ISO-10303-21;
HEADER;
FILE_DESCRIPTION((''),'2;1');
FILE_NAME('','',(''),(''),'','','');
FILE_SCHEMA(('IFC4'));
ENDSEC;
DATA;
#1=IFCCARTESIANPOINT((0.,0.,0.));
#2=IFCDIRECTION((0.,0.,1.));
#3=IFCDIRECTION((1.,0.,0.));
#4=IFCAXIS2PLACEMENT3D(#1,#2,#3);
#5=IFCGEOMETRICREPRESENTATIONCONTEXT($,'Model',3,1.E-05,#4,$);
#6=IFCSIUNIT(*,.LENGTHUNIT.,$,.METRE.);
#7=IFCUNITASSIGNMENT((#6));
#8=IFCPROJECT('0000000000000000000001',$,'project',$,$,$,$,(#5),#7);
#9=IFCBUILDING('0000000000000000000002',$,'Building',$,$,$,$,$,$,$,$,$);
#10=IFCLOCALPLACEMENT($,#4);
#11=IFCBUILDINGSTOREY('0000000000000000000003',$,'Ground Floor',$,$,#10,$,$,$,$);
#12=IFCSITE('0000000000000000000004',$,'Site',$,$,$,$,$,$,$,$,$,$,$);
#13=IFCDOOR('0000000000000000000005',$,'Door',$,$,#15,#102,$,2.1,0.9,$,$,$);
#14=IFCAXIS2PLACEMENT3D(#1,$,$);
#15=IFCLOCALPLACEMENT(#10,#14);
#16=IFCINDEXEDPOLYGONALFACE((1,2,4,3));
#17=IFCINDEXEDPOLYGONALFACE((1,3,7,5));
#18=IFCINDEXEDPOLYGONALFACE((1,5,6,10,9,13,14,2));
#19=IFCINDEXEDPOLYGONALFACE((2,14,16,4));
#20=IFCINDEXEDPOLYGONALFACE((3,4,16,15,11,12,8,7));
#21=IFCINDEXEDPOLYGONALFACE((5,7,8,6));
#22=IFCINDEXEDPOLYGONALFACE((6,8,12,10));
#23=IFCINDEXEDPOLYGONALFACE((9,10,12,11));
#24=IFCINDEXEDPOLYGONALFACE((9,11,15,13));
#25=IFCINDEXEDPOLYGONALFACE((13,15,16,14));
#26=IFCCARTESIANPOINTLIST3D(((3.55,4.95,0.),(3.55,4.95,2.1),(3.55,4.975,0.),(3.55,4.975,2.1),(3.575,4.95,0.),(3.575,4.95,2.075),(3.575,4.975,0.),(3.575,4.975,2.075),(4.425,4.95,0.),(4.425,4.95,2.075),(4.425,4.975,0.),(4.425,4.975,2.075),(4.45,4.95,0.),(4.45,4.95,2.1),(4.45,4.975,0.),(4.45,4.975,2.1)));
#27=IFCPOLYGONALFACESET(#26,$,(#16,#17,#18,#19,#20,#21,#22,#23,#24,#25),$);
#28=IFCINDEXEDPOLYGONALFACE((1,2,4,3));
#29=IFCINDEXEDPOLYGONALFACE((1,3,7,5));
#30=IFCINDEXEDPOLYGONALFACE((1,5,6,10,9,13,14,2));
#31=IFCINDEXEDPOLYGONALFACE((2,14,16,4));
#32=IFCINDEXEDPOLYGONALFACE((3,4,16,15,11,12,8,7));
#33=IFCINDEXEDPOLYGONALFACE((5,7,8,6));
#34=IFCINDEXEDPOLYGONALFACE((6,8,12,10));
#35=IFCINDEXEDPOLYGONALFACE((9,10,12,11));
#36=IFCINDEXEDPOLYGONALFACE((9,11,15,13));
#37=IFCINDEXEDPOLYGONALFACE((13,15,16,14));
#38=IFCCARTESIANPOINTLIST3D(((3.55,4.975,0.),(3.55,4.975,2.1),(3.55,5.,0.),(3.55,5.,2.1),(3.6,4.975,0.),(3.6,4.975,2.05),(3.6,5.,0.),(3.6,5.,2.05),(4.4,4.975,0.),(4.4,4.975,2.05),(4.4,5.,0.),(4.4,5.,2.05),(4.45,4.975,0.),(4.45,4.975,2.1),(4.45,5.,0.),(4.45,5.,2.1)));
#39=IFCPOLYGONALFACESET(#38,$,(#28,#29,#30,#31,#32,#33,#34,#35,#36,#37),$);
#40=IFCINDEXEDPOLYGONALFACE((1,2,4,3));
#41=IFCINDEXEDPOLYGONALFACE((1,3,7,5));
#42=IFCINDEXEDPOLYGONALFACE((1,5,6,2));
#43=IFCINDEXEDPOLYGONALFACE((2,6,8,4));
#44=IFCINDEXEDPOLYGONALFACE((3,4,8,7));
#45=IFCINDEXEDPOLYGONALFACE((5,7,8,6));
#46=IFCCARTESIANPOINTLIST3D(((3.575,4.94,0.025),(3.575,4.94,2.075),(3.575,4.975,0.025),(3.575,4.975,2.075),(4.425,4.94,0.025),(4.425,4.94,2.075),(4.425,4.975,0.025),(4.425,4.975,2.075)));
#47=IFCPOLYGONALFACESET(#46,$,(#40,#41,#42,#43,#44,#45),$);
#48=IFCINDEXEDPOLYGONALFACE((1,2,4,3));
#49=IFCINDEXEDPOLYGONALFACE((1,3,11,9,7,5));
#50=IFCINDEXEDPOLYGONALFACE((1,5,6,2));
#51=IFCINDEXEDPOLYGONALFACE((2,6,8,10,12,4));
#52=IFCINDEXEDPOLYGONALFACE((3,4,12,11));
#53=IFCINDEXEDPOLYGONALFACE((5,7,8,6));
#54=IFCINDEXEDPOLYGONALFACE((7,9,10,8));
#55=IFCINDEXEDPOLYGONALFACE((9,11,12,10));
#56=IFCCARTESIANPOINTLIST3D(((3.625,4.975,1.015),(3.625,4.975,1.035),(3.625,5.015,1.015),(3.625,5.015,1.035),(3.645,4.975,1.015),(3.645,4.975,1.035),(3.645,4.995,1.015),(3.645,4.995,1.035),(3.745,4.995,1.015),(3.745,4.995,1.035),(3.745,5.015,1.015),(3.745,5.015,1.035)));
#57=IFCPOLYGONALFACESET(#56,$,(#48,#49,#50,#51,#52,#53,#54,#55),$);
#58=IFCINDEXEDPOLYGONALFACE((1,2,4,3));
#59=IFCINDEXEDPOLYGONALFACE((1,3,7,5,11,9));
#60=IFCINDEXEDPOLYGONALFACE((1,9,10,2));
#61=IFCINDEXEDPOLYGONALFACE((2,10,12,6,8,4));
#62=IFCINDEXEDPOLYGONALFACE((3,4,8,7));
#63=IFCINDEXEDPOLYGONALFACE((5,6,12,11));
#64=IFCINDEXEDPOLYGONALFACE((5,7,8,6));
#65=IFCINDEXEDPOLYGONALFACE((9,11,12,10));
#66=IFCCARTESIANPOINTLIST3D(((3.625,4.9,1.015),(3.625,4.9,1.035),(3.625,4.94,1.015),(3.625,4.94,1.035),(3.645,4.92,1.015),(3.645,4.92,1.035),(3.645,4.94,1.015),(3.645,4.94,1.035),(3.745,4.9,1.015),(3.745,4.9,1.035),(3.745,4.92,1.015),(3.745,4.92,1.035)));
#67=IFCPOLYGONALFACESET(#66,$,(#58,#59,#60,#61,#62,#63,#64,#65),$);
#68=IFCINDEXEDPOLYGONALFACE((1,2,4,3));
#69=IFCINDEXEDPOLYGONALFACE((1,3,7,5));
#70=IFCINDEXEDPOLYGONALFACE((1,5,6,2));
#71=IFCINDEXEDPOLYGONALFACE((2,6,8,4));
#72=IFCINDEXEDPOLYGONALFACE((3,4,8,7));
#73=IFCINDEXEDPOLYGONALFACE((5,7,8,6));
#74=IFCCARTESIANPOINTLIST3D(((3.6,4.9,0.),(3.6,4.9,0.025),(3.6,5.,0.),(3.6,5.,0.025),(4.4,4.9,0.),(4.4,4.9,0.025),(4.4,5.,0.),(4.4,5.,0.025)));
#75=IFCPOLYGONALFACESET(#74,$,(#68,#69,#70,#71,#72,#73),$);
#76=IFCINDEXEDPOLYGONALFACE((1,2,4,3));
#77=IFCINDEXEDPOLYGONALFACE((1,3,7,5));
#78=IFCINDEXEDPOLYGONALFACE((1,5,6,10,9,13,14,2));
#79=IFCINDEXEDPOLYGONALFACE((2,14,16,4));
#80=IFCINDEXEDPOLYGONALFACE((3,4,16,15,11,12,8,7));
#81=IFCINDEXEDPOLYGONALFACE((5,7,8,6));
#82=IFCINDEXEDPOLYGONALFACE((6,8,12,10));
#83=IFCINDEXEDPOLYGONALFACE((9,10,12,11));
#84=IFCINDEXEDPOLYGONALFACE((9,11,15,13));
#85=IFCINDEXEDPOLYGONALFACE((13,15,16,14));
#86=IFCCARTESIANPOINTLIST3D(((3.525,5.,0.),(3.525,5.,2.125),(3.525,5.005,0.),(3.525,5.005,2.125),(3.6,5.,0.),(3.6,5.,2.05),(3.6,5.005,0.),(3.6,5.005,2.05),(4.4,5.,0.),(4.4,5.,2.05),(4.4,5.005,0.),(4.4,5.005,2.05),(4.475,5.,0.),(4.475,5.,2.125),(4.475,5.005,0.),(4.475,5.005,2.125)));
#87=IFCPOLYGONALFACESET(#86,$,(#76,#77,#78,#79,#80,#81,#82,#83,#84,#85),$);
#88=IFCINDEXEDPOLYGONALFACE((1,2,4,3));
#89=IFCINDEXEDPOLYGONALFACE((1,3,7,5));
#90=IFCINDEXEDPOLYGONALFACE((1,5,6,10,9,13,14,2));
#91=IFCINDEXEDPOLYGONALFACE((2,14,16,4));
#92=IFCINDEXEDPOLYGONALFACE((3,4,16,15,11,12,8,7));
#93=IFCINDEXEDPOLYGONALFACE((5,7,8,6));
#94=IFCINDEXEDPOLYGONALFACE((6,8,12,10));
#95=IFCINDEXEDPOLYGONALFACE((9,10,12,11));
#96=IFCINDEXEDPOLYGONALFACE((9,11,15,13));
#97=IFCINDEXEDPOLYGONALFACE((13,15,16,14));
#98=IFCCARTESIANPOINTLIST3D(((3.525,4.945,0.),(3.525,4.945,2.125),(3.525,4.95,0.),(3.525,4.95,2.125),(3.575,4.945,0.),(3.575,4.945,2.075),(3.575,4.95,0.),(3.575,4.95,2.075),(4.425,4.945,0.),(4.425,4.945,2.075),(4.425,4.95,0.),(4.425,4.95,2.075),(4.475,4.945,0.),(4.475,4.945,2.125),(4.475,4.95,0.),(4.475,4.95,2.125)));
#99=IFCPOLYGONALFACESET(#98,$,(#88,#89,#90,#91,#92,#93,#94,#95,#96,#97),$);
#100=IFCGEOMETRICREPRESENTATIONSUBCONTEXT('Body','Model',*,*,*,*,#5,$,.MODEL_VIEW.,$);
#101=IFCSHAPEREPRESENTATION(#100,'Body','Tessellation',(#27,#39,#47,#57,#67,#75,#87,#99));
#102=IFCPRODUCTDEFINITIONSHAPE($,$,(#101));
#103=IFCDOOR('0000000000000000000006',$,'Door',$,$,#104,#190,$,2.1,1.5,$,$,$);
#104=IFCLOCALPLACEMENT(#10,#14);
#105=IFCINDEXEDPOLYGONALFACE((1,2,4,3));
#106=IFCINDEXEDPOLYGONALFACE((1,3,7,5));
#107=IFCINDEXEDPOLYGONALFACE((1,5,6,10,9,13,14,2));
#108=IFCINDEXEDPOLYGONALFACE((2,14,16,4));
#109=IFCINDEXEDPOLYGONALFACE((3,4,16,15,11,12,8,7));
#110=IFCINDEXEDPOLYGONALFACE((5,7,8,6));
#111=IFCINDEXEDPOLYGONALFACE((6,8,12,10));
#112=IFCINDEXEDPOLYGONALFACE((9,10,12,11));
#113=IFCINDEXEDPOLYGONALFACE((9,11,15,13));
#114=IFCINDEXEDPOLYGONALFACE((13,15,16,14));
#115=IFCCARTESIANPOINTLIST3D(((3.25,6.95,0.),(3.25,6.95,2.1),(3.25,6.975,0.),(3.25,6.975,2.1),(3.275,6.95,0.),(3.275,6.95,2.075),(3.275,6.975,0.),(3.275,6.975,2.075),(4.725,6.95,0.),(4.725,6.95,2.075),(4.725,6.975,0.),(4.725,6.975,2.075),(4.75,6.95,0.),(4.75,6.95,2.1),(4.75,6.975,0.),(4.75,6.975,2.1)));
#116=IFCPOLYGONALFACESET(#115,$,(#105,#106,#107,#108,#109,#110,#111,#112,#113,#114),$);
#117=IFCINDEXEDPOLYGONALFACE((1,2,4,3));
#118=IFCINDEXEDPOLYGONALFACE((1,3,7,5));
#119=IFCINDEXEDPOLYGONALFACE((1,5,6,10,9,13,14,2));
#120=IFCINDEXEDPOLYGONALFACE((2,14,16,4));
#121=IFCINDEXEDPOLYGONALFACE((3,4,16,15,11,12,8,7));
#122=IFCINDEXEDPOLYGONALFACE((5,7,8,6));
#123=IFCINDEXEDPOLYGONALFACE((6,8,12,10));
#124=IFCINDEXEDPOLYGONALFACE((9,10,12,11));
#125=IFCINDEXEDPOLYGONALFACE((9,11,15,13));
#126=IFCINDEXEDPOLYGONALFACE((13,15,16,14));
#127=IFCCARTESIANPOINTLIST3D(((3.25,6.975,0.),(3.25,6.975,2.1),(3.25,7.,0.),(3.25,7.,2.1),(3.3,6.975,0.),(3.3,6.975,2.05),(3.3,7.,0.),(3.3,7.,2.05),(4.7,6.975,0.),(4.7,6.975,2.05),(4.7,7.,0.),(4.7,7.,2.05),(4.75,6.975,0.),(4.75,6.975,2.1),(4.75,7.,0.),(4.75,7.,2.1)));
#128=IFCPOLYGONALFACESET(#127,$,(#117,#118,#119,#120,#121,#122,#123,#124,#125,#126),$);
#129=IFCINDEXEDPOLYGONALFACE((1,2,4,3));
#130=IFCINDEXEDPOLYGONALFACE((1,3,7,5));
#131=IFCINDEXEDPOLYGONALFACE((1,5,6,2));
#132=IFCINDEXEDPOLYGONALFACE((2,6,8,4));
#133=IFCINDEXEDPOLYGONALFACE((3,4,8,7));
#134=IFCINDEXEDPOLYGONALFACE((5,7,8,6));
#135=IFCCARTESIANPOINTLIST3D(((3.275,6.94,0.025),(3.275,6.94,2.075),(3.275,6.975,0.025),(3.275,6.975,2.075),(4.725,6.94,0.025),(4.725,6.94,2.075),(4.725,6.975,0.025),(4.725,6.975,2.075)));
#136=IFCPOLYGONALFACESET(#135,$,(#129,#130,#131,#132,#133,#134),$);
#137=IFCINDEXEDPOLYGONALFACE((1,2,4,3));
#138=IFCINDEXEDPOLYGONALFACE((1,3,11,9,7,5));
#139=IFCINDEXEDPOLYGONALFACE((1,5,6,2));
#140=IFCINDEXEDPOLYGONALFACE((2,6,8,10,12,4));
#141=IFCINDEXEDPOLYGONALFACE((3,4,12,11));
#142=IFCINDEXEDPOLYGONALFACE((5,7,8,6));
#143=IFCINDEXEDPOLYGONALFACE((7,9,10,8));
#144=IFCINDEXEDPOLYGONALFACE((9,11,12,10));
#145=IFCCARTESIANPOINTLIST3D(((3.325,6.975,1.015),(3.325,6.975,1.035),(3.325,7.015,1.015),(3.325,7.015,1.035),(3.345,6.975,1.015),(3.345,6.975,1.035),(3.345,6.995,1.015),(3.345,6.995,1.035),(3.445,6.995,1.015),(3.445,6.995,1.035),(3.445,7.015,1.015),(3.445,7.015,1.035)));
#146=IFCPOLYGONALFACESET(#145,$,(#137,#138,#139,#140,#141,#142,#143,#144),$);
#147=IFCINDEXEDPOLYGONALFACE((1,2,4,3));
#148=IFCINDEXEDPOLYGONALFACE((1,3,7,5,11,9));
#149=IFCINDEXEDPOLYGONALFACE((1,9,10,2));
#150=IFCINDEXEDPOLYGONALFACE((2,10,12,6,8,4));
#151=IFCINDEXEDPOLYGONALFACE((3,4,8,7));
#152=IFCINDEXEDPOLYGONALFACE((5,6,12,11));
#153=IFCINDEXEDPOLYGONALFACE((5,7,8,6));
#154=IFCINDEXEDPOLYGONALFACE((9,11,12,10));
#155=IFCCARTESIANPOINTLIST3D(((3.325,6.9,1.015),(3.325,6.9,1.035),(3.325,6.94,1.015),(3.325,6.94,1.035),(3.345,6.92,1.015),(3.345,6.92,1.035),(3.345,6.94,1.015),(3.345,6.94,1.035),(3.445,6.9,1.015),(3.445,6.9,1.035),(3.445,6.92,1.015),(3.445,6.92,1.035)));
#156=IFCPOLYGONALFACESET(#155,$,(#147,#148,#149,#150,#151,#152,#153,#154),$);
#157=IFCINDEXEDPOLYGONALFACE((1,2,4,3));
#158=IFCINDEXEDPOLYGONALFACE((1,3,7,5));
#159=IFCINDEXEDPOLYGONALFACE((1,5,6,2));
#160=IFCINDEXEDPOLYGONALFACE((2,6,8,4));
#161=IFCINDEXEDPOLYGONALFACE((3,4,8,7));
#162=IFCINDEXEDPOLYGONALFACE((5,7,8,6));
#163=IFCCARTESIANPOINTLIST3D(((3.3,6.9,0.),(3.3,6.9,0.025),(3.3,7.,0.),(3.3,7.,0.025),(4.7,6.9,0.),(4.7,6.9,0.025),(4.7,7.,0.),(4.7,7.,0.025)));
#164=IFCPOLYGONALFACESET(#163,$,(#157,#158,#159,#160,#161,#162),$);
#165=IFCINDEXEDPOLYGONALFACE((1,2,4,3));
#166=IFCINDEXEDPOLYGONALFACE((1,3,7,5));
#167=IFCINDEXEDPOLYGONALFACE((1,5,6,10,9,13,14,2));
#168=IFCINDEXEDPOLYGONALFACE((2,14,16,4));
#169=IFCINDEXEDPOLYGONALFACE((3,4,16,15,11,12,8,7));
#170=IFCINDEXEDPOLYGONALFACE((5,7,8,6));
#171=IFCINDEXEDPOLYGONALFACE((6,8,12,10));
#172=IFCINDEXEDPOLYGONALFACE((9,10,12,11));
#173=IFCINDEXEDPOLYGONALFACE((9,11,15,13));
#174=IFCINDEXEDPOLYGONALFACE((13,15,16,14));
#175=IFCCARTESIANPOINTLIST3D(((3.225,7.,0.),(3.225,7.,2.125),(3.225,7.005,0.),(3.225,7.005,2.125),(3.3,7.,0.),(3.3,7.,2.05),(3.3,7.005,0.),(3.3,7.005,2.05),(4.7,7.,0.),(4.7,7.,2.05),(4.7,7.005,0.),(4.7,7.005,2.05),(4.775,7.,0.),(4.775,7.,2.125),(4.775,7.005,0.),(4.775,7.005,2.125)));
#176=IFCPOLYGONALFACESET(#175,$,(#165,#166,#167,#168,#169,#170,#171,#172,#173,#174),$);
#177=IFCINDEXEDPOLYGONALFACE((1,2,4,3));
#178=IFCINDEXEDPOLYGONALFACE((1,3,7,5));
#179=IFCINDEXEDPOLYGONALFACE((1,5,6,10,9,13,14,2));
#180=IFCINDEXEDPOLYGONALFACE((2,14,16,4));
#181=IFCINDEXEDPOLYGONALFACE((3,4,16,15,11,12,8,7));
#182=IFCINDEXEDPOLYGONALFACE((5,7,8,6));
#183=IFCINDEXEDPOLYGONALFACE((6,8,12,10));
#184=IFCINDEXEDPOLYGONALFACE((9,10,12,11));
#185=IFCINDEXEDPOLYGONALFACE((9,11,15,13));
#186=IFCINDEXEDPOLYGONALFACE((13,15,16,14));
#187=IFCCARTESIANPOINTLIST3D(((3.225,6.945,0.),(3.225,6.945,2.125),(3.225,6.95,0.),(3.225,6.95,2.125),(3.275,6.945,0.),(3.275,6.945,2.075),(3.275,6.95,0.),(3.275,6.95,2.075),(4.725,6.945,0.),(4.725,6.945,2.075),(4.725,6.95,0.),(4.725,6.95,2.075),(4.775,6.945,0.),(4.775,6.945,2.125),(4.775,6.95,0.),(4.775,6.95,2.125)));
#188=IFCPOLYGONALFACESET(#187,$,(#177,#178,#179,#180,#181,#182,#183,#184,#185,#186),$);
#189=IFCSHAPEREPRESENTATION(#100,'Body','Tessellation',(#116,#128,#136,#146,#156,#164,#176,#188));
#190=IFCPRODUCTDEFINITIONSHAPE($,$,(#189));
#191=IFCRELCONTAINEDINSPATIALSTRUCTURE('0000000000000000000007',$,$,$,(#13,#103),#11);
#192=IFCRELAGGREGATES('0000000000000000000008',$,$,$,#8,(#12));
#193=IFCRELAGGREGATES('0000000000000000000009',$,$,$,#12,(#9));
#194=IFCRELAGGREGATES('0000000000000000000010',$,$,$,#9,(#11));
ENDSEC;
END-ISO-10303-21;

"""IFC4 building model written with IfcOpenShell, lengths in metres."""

from ifc_helpers import new_model, si_unit, frame, origin_with_axes, place, context, subcontext, project, spatial, line, indexed_curve, outline, extrude, element, save


model = new_model("IFC4")

# Units and contexts
model_context = context("Model", 3, precision=1e-05, world=origin_with_axes())
body_context = subcontext(model_context, "Body", "Model", "MODEL_VIEW")
ifc_project = project(units=[si_unit("LENGTHUNIT", "METRE")], contexts=[model_context])

# Site, building, storey
site = spatial("IfcSite", under=ifc_project, Name="Site")
building = spatial("IfcBuilding", under=site, Name="Building")
storey_placement = place(None, origin_with_axes())
storey = spatial("IfcBuildingStorey", under=building, at=storey_placement, Name="Ground Floor")

# Doors
door_1_placement = place(storey_placement, frame((4.45, 5.0, 0.0), z_axis=(0.0, 0.0, 1.0), x_axis=(-1.0, 0.0, 0.0)))
element("IfcDoor", 1, at=door_1_placement, inside=storey, Name="Door", OverallHeight=2.1, OverallWidth=0.9, context=body_context, shape_type="SweptSolid", body=[
    extrude(outline(indexed_curve([(0.0, 0.0), (0.0, 2.1), (0.9, 2.1), (0.9, 0.0), (0.875, 0.0), (0.875, 2.075), (0.025, 2.075), (0.025, 0.0)], segments=[line(1, 2, 3, 4, 5, 6, 7, 8, 1)])), frame((0.0, 0.025, 0.0), z_axis=(0.0, -1.0, 0.0), x_axis=(1.0, 0.0, 0.0)), (0.0, 0.0, -1.0), 0.025),
    extrude(outline(indexed_curve([(0.0, 0.0), (0.0, 2.1), (0.9, 2.1), (0.9, 0.0), (0.85, 0.0), (0.85, 2.05), (0.05, 2.05), (0.05, 0.0)], segments=[line(1, 2, 3, 4, 5, 6, 7, 8, 1)])), frame((0.0, 0.0, 0.0), z_axis=(0.0, -1.0, 0.0), x_axis=(1.0, 0.0, 0.0)), (0.0, 0.0, -1.0), 0.025),
    extrude(outline(indexed_curve([(0.0, 0.0), (0.85, 0.0), (0.85, 0.035), (0.0, 0.035)], segments=[line(1, 2, 3, 4, 1)])), frame((0.025, 0.025, 0.025), z_axis=(0.0, 0.0, 1.0), x_axis=(1.0, 0.0, 0.0)), (0.0, 0.0, 1.0), 2.05),
    extrude(outline(indexed_curve([(0.0, 0.0), (0.0, -0.04), (-0.12, -0.04), (-0.12, -0.02), (-0.02, -0.02), (-0.02, 0.0)], segments=[line(1, 2, 3, 4, 5, 6, 1)])), frame((0.825, 0.025, 1.015), z_axis=(0.0, 0.0, 1.0), x_axis=(1.0, 0.0, 0.0)), (0.0, 0.0, 1.0), 0.02),
    extrude(outline(indexed_curve([(0.0, 0.0), (0.0, 0.04), (-0.12, 0.04), (-0.12, 0.02), (-0.02, 0.02), (-0.02, 0.0)], segments=[line(1, 2, 3, 4, 5, 6, 1)])), frame((0.825, 0.06, 1.015), z_axis=(0.0, 0.0, 1.0), x_axis=(1.0, 0.0, 0.0)), (0.0, 0.0, 1.0), 0.02),
    extrude(outline(indexed_curve([(0.0, 0.0), (0.8, 0.0), (0.8, 0.1), (0.0, 0.1)], segments=[line(1, 2, 3, 4, 1)])), frame((0.05, 0.0, 0.0), z_axis=(0.0, 0.0, 1.0), x_axis=(1.0, 0.0, 0.0)), (0.0, 0.0, 1.0), 0.025),
    extrude(outline(indexed_curve([(0.0, 0.0), (0.0, 2.125), (0.95, 2.125), (0.95, 0.0), (0.875, 0.0), (0.875, 2.05), (0.075, 2.05), (0.075, 0.0)], segments=[line(1, 2, 3, 4, 5, 6, 7, 8, 1)])), frame((-0.025, -0.005, 0.0), z_axis=(0.0, -1.0, 0.0), x_axis=(1.0, 0.0, 0.0)), (0.0, 0.0, -1.0), 0.005),
    extrude(outline(indexed_curve([(0.0, 0.0), (0.0, 2.125), (0.95, 2.125), (0.95, 0.0), (0.9, 0.0), (0.9, 2.075), (0.05, 2.075), (0.05, 0.0)], segments=[line(1, 2, 3, 4, 5, 6, 7, 8, 1)])), frame((-0.025, 0.05, 0.0), z_axis=(0.0, -1.0, 0.0), x_axis=(1.0, 0.0, 0.0)), (0.0, 0.0, -1.0), 0.005),
])
door_2_placement = place(storey_placement, frame((4.75, 7.0, 0.0), z_axis=(0.0, 0.0, 1.0), x_axis=(-1.0, 0.0, 0.0)))
element("IfcDoor", 2, at=door_2_placement, inside=storey, Name="Door", OverallHeight=2.1, OverallWidth=1.5, context=body_context, shape_type="SweptSolid", body=[
    extrude(outline(indexed_curve([(0.0, 0.0), (0.0, 2.1), (1.5, 2.1), (1.5, 0.0), (1.475, 0.0), (1.475, 2.075), (0.025, 2.075), (0.025, 0.0)], segments=[line(1, 2, 3, 4, 5, 6, 7, 8, 1)])), frame((0.0, 0.025, 0.0), z_axis=(0.0, -1.0, 0.0), x_axis=(1.0, 0.0, 0.0)), (0.0, 0.0, -1.0), 0.025),
    extrude(outline(indexed_curve([(0.0, 0.0), (0.0, 2.1), (1.5, 2.1), (1.5, 0.0), (1.45, 0.0), (1.45, 2.05), (0.05, 2.05), (0.05, 0.0)], segments=[line(1, 2, 3, 4, 5, 6, 7, 8, 1)])), frame((0.0, 0.0, 0.0), z_axis=(0.0, -1.0, 0.0), x_axis=(1.0, 0.0, 0.0)), (0.0, 0.0, -1.0), 0.025),
    extrude(outline(indexed_curve([(0.0, 0.0), (1.45, 0.0), (1.45, 0.035), (0.0, 0.035)], segments=[line(1, 2, 3, 4, 1)])), frame((0.025, 0.025, 0.025), z_axis=(0.0, 0.0, 1.0), x_axis=(1.0, 0.0, 0.0)), (0.0, 0.0, 1.0), 2.05),
    extrude(outline(indexed_curve([(0.0, 0.0), (0.0, -0.04), (-0.12, -0.04), (-0.12, -0.02), (-0.02, -0.02), (-0.02, 0.0)], segments=[line(1, 2, 3, 4, 5, 6, 1)])), frame((1.425, 0.025, 1.015), z_axis=(0.0, 0.0, 1.0), x_axis=(1.0, 0.0, 0.0)), (0.0, 0.0, 1.0), 0.02),
    extrude(outline(indexed_curve([(0.0, 0.0), (0.0, 0.04), (-0.12, 0.04), (-0.12, 0.02), (-0.02, 0.02), (-0.02, 0.0)], segments=[line(1, 2, 3, 4, 5, 6, 1)])), frame((1.425, 0.06, 1.015), z_axis=(0.0, 0.0, 1.0), x_axis=(1.0, 0.0, 0.0)), (0.0, 0.0, 1.0), 0.02),
    extrude(outline(indexed_curve([(0.0, 0.0), (1.4, 0.0), (1.4, 0.1), (0.0, 0.1)], segments=[line(1, 2, 3, 4, 1)])), frame((0.05, 0.0, 0.0), z_axis=(0.0, 0.0, 1.0), x_axis=(1.0, 0.0, 0.0)), (0.0, 0.0, 1.0), 0.025),
    extrude(outline(indexed_curve([(0.0, 0.0), (0.0, 2.125), (1.55, 2.125), (1.55, 0.0), (1.475, 0.0), (1.475, 2.05), (0.075, 2.05), (0.075, 0.0)], segments=[line(1, 2, 3, 4, 5, 6, 7, 8, 1)])), frame((-0.025, -0.005, 0.0), z_axis=(0.0, -1.0, 0.0), x_axis=(1.0, 0.0, 0.0)), (0.0, 0.0, -1.0), 0.005),
    extrude(outline(indexed_curve([(0.0, 0.0), (0.0, 2.125), (1.55, 2.125), (1.55, 0.0), (1.5, 0.0), (1.5, 2.075), (0.05, 2.075), (0.05, 0.0)], segments=[line(1, 2, 3, 4, 5, 6, 7, 8, 1)])), frame((-0.025, 0.05, 0.0), z_axis=(0.0, -1.0, 0.0), x_axis=(1.0, 0.0, 0.0)), (0.0, 0.0, -1.0), 0.005),
])

save(model, "model.ifc")
